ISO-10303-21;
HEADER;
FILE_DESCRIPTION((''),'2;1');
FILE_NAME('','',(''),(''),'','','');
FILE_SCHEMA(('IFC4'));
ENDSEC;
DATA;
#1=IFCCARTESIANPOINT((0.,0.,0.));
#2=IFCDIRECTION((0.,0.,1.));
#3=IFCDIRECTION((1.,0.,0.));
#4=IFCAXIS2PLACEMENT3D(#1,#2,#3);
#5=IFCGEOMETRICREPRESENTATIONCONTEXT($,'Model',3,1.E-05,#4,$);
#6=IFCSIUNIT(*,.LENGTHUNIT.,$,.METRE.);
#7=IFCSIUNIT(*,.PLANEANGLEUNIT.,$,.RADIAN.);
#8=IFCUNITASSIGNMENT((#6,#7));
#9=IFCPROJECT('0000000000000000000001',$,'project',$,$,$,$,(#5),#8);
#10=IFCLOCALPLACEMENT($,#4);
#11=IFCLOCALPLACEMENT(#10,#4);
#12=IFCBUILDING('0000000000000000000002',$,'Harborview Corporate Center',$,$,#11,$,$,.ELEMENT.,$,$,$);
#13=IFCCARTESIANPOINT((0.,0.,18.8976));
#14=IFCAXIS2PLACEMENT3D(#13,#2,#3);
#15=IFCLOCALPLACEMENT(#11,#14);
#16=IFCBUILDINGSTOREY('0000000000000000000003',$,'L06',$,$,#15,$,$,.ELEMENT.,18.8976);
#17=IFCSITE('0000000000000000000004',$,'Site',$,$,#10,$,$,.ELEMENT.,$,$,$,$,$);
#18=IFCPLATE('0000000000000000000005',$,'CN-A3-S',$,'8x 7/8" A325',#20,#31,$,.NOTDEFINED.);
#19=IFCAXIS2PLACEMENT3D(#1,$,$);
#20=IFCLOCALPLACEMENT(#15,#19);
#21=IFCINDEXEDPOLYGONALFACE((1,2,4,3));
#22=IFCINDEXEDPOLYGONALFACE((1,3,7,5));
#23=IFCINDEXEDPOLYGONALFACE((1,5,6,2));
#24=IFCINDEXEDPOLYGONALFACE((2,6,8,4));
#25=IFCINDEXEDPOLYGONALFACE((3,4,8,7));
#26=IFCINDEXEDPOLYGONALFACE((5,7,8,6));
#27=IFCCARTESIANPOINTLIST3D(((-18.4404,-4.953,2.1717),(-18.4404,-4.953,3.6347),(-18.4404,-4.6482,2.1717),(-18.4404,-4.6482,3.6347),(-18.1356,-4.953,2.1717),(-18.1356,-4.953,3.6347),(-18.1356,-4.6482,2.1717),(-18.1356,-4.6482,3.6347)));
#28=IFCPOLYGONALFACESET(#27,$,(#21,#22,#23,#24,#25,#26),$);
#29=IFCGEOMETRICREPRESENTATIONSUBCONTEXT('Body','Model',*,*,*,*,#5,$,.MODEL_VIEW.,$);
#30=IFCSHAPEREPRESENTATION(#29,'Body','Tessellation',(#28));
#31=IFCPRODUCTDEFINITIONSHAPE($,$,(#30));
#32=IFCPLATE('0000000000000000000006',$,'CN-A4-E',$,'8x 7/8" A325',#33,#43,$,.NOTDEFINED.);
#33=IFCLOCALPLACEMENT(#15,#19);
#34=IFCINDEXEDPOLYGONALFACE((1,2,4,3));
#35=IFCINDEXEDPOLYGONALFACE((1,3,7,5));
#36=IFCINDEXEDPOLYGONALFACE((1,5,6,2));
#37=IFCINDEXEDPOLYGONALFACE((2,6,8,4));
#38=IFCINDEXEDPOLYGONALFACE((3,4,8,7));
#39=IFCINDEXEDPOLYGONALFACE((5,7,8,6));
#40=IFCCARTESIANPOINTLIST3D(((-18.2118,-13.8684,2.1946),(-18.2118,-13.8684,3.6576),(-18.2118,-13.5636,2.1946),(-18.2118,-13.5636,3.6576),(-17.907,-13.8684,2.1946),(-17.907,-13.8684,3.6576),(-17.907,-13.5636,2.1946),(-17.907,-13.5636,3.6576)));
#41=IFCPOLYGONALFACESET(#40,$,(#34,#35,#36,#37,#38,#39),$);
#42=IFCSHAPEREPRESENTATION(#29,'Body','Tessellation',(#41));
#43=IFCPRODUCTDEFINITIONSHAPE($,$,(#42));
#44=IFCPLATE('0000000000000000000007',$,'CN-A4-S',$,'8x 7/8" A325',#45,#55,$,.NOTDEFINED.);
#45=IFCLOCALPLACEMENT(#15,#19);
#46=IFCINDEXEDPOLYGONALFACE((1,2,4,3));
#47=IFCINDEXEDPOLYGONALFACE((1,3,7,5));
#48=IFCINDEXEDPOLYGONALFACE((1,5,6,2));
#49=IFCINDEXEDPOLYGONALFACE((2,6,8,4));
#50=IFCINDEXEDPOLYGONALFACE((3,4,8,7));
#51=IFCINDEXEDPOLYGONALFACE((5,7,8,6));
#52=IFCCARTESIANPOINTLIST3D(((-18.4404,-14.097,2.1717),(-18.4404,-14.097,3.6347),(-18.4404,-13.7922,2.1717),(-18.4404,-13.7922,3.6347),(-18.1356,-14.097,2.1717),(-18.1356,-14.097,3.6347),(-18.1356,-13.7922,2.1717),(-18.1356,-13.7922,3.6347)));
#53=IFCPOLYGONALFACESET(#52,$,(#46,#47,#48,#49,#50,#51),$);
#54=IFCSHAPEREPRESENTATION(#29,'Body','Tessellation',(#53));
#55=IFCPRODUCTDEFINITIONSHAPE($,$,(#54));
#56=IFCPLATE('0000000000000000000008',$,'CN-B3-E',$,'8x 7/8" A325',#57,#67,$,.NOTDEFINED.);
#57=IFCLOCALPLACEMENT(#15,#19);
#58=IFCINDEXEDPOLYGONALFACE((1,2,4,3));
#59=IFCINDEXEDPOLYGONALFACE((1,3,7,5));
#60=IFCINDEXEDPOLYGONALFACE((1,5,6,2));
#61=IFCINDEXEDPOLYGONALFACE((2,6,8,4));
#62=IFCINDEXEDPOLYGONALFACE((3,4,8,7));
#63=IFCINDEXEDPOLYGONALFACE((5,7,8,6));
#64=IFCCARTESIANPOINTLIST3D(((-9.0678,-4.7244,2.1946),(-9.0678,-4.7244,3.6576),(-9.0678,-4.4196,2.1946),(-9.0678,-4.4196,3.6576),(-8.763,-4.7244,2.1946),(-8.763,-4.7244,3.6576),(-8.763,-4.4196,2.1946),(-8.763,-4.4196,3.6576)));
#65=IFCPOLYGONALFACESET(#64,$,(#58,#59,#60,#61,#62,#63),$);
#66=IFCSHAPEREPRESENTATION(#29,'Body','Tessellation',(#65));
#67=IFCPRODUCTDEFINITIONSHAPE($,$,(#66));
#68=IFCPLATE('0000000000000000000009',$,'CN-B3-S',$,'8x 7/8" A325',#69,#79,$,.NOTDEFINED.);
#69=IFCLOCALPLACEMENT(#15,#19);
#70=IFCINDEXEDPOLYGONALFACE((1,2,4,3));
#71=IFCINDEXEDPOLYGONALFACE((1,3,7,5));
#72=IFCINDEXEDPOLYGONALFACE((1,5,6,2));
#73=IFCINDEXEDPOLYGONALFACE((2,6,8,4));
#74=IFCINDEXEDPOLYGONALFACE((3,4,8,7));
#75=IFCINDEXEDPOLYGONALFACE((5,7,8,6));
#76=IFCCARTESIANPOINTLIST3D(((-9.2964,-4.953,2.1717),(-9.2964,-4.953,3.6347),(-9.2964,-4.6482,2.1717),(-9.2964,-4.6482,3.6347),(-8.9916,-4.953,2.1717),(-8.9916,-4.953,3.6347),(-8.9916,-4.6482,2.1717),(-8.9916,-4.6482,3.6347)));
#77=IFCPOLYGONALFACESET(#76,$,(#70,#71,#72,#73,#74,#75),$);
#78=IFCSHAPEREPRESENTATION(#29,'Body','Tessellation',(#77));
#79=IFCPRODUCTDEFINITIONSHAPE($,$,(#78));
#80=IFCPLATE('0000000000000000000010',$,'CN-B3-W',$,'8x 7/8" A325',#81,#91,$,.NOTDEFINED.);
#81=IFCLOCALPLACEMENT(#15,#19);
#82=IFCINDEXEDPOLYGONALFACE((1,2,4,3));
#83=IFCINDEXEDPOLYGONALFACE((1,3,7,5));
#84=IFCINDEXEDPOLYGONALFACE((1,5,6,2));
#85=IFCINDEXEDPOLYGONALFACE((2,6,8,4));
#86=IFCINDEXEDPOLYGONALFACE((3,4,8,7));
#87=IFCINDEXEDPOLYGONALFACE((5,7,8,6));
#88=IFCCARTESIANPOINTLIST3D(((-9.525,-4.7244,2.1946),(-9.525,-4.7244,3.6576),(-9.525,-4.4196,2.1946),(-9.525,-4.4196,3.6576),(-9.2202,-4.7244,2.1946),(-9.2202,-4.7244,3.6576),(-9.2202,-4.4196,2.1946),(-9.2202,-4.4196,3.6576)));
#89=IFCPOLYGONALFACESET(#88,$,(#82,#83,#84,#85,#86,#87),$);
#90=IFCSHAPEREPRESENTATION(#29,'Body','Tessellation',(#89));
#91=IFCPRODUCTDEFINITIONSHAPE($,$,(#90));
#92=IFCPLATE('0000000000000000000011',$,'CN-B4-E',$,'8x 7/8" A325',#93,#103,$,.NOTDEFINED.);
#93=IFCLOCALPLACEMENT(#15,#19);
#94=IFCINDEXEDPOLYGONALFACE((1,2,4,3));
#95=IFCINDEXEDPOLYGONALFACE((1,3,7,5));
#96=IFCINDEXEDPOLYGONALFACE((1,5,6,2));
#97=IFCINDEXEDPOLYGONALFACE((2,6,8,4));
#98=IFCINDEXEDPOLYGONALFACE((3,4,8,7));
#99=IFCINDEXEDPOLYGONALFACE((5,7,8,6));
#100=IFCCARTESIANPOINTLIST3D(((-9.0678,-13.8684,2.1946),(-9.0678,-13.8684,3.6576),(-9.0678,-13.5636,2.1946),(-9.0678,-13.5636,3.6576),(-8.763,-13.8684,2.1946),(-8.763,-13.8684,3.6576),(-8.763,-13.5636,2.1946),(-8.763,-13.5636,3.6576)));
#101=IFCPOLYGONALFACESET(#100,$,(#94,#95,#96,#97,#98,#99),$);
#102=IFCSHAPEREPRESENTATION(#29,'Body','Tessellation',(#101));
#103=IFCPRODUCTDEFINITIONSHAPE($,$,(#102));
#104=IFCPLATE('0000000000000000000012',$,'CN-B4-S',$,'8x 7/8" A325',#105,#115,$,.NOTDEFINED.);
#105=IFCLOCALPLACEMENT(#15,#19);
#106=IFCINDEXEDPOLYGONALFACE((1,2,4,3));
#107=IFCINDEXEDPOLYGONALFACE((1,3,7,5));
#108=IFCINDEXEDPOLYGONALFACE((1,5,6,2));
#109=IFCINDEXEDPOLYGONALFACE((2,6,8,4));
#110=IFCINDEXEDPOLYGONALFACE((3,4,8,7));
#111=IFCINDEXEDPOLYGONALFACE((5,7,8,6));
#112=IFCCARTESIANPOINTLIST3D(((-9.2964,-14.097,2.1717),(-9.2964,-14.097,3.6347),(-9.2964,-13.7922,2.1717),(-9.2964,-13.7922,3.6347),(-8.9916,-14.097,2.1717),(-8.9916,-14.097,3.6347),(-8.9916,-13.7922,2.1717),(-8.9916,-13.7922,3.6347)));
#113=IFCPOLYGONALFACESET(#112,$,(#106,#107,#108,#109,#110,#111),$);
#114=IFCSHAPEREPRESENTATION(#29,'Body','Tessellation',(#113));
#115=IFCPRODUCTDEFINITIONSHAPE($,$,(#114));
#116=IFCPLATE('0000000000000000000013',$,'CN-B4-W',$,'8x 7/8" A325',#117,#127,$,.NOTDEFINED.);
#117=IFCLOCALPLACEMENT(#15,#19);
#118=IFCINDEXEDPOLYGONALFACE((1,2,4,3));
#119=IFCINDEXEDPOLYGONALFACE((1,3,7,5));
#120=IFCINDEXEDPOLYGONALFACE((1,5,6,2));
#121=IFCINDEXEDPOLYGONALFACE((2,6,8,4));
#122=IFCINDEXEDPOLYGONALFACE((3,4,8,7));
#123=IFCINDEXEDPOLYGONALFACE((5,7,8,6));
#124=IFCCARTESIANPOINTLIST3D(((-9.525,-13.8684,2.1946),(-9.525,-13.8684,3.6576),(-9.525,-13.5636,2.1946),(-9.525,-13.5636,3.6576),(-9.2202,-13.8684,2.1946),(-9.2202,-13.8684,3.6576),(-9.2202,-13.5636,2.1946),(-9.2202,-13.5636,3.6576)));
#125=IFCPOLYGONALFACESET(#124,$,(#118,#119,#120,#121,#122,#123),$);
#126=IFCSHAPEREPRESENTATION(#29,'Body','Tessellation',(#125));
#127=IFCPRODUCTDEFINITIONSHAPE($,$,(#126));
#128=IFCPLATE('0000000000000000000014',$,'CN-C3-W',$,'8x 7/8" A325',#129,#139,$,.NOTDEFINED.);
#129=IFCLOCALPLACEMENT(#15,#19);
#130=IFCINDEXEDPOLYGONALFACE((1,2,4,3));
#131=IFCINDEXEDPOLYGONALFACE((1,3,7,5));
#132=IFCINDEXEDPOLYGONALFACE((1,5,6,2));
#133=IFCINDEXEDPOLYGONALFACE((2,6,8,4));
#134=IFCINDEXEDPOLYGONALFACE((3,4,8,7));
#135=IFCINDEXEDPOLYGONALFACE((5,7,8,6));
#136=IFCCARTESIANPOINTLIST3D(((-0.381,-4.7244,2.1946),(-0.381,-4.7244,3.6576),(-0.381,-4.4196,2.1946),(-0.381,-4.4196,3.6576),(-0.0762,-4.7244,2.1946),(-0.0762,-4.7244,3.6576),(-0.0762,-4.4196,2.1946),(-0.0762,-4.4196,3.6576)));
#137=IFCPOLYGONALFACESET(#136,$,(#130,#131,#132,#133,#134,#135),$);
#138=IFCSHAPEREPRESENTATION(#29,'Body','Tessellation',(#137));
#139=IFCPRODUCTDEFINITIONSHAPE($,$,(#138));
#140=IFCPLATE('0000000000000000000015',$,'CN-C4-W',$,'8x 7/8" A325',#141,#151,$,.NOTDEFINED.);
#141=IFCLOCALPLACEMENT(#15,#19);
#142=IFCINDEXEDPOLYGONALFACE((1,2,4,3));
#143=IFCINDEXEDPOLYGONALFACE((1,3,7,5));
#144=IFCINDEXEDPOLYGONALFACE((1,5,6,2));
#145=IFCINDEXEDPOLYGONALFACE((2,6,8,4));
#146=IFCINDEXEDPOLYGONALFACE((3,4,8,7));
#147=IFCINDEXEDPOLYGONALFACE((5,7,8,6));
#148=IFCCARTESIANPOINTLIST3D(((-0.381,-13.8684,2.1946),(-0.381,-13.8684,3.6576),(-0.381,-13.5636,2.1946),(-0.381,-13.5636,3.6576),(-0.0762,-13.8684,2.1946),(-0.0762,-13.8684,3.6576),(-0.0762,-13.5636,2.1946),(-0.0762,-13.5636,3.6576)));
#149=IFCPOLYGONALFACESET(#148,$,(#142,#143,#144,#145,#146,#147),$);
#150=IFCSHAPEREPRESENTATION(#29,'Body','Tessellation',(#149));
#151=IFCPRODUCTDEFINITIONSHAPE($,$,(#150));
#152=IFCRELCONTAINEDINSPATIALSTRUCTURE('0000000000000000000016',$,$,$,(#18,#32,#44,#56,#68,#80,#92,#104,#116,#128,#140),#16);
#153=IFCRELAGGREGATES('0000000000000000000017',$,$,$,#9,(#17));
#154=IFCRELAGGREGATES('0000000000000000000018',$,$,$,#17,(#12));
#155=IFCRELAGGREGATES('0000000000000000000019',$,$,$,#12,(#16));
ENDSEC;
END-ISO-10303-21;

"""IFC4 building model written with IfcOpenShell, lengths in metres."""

from ifc_helpers import new_model, si_unit, frame, origin_with_axes, place, context, subcontext, project, spatial, rectangle, extrude, element, save


model = new_model("IFC4")

# Units and contexts
model_context = context("Model", 3, precision=1e-05, world=origin_with_axes())
body_context = subcontext(model_context, "Body", "Model", "MODEL_VIEW")
ifc_project = project(units=[si_unit("LENGTHUNIT", "METRE"), si_unit("PLANEANGLEUNIT", "RADIAN")], contexts=[model_context])

# Site, building, storey
site_placement = place(None, origin_with_axes())
site = spatial("IfcSite", under=ifc_project, at=site_placement, Name="Site", CompositionType="ELEMENT")
building_placement = place(site_placement, origin_with_axes())
building = spatial("IfcBuilding", under=site, at=building_placement, Name="Harborview Corporate Center", CompositionType="ELEMENT")
storey_placement = place(building_placement, frame((0.0, 0.0, 18.8976), z_axis=(0.0, 0.0, 1.0), x_axis=(1.0, 0.0, 0.0)))
storey = spatial("IfcBuildingStorey", under=building, at=storey_placement, Name="L06", CompositionType="ELEMENT", Elevation=18.8976)

# Plates
for number, where, z_axis, x_axis, name in (
    (1, (-18.288, -4.8006, 2.1717), (0.0, 0.0, 1.0), (1.0, 0.0, 0.0), "CN-A3-S"),
    (2, (-18.0594, -13.716, 2.1946), (0.0, 0.0, 1.0), (1.0, 0.0, 0.0), "CN-A4-E"),
    (3, (-18.288, -13.9446, 2.1717), (0.0, 0.0, 1.0), (1.0, 0.0, 0.0), "CN-A4-S"),
    (4, (-8.9154, -4.572, 2.1946), (0.0, 0.0, 1.0), (1.0, 0.0, 0.0), "CN-B3-E"),
    (5, (-9.144, -4.8006, 2.1717), (0.0, 0.0, 1.0), (1.0, 0.0, 0.0), "CN-B3-S"),
    (6, (-9.3726, -4.572, 2.1946), (0.0, 0.0, 1.0), (1.0, 0.0, 0.0), "CN-B3-W"),
    (7, (-8.9154, -13.716, 2.1946), (0.0, 0.0, 1.0), (1.0, 0.0, 0.0), "CN-B4-E"),
    (8, (-9.144, -13.9446, 2.1717), (0.0, 0.0, 1.0), (1.0, 0.0, 0.0), "CN-B4-S"),
    (9, (-9.3726, -13.716, 2.1946), (0.0, 0.0, 1.0), (1.0, 0.0, 0.0), "CN-B4-W"),
):
    element("IfcPlate", number, at=place(storey_placement, frame(where, z_axis=z_axis, x_axis=x_axis)), inside=storey, Name=name, ObjectType="8x 7/8\" A325", PredefinedType="NOTDEFINED", context=body_context, shape_type="SweptSolid", body=[
        extrude(rectangle(XDim=0.3048, YDim=0.3048), origin_with_axes(), (0.0, 0.0, 1.0), 1.463),
    ])
for number, where, z_axis, x_axis, name in (
    (10, (-0.2286, -4.572, 2.1946), (0.0, 0.0, 1.0), (1.0, 0.0, 0.0), "CN-C3-W"),
    (11, (-0.2286, -13.716, 2.1946), (0.0, 0.0, 1.0), (1.0, 0.0, 0.0), "CN-C4-W"),
):
    element("IfcPlate", number, at=place(storey_placement, frame(where, z_axis=z_axis, x_axis=x_axis)), inside=storey, Name=name, ObjectType="8x 7/8\" A325", PredefinedType="NOTDEFINED", context=body_context, shape_type="SweptSolid", body=[
        extrude(rectangle(XDim=0.3048, YDim=0.3048), origin_with_axes(), (0.0, 0.0, 1.0), 1.463),
    ])

save(model, "model.ifc")
